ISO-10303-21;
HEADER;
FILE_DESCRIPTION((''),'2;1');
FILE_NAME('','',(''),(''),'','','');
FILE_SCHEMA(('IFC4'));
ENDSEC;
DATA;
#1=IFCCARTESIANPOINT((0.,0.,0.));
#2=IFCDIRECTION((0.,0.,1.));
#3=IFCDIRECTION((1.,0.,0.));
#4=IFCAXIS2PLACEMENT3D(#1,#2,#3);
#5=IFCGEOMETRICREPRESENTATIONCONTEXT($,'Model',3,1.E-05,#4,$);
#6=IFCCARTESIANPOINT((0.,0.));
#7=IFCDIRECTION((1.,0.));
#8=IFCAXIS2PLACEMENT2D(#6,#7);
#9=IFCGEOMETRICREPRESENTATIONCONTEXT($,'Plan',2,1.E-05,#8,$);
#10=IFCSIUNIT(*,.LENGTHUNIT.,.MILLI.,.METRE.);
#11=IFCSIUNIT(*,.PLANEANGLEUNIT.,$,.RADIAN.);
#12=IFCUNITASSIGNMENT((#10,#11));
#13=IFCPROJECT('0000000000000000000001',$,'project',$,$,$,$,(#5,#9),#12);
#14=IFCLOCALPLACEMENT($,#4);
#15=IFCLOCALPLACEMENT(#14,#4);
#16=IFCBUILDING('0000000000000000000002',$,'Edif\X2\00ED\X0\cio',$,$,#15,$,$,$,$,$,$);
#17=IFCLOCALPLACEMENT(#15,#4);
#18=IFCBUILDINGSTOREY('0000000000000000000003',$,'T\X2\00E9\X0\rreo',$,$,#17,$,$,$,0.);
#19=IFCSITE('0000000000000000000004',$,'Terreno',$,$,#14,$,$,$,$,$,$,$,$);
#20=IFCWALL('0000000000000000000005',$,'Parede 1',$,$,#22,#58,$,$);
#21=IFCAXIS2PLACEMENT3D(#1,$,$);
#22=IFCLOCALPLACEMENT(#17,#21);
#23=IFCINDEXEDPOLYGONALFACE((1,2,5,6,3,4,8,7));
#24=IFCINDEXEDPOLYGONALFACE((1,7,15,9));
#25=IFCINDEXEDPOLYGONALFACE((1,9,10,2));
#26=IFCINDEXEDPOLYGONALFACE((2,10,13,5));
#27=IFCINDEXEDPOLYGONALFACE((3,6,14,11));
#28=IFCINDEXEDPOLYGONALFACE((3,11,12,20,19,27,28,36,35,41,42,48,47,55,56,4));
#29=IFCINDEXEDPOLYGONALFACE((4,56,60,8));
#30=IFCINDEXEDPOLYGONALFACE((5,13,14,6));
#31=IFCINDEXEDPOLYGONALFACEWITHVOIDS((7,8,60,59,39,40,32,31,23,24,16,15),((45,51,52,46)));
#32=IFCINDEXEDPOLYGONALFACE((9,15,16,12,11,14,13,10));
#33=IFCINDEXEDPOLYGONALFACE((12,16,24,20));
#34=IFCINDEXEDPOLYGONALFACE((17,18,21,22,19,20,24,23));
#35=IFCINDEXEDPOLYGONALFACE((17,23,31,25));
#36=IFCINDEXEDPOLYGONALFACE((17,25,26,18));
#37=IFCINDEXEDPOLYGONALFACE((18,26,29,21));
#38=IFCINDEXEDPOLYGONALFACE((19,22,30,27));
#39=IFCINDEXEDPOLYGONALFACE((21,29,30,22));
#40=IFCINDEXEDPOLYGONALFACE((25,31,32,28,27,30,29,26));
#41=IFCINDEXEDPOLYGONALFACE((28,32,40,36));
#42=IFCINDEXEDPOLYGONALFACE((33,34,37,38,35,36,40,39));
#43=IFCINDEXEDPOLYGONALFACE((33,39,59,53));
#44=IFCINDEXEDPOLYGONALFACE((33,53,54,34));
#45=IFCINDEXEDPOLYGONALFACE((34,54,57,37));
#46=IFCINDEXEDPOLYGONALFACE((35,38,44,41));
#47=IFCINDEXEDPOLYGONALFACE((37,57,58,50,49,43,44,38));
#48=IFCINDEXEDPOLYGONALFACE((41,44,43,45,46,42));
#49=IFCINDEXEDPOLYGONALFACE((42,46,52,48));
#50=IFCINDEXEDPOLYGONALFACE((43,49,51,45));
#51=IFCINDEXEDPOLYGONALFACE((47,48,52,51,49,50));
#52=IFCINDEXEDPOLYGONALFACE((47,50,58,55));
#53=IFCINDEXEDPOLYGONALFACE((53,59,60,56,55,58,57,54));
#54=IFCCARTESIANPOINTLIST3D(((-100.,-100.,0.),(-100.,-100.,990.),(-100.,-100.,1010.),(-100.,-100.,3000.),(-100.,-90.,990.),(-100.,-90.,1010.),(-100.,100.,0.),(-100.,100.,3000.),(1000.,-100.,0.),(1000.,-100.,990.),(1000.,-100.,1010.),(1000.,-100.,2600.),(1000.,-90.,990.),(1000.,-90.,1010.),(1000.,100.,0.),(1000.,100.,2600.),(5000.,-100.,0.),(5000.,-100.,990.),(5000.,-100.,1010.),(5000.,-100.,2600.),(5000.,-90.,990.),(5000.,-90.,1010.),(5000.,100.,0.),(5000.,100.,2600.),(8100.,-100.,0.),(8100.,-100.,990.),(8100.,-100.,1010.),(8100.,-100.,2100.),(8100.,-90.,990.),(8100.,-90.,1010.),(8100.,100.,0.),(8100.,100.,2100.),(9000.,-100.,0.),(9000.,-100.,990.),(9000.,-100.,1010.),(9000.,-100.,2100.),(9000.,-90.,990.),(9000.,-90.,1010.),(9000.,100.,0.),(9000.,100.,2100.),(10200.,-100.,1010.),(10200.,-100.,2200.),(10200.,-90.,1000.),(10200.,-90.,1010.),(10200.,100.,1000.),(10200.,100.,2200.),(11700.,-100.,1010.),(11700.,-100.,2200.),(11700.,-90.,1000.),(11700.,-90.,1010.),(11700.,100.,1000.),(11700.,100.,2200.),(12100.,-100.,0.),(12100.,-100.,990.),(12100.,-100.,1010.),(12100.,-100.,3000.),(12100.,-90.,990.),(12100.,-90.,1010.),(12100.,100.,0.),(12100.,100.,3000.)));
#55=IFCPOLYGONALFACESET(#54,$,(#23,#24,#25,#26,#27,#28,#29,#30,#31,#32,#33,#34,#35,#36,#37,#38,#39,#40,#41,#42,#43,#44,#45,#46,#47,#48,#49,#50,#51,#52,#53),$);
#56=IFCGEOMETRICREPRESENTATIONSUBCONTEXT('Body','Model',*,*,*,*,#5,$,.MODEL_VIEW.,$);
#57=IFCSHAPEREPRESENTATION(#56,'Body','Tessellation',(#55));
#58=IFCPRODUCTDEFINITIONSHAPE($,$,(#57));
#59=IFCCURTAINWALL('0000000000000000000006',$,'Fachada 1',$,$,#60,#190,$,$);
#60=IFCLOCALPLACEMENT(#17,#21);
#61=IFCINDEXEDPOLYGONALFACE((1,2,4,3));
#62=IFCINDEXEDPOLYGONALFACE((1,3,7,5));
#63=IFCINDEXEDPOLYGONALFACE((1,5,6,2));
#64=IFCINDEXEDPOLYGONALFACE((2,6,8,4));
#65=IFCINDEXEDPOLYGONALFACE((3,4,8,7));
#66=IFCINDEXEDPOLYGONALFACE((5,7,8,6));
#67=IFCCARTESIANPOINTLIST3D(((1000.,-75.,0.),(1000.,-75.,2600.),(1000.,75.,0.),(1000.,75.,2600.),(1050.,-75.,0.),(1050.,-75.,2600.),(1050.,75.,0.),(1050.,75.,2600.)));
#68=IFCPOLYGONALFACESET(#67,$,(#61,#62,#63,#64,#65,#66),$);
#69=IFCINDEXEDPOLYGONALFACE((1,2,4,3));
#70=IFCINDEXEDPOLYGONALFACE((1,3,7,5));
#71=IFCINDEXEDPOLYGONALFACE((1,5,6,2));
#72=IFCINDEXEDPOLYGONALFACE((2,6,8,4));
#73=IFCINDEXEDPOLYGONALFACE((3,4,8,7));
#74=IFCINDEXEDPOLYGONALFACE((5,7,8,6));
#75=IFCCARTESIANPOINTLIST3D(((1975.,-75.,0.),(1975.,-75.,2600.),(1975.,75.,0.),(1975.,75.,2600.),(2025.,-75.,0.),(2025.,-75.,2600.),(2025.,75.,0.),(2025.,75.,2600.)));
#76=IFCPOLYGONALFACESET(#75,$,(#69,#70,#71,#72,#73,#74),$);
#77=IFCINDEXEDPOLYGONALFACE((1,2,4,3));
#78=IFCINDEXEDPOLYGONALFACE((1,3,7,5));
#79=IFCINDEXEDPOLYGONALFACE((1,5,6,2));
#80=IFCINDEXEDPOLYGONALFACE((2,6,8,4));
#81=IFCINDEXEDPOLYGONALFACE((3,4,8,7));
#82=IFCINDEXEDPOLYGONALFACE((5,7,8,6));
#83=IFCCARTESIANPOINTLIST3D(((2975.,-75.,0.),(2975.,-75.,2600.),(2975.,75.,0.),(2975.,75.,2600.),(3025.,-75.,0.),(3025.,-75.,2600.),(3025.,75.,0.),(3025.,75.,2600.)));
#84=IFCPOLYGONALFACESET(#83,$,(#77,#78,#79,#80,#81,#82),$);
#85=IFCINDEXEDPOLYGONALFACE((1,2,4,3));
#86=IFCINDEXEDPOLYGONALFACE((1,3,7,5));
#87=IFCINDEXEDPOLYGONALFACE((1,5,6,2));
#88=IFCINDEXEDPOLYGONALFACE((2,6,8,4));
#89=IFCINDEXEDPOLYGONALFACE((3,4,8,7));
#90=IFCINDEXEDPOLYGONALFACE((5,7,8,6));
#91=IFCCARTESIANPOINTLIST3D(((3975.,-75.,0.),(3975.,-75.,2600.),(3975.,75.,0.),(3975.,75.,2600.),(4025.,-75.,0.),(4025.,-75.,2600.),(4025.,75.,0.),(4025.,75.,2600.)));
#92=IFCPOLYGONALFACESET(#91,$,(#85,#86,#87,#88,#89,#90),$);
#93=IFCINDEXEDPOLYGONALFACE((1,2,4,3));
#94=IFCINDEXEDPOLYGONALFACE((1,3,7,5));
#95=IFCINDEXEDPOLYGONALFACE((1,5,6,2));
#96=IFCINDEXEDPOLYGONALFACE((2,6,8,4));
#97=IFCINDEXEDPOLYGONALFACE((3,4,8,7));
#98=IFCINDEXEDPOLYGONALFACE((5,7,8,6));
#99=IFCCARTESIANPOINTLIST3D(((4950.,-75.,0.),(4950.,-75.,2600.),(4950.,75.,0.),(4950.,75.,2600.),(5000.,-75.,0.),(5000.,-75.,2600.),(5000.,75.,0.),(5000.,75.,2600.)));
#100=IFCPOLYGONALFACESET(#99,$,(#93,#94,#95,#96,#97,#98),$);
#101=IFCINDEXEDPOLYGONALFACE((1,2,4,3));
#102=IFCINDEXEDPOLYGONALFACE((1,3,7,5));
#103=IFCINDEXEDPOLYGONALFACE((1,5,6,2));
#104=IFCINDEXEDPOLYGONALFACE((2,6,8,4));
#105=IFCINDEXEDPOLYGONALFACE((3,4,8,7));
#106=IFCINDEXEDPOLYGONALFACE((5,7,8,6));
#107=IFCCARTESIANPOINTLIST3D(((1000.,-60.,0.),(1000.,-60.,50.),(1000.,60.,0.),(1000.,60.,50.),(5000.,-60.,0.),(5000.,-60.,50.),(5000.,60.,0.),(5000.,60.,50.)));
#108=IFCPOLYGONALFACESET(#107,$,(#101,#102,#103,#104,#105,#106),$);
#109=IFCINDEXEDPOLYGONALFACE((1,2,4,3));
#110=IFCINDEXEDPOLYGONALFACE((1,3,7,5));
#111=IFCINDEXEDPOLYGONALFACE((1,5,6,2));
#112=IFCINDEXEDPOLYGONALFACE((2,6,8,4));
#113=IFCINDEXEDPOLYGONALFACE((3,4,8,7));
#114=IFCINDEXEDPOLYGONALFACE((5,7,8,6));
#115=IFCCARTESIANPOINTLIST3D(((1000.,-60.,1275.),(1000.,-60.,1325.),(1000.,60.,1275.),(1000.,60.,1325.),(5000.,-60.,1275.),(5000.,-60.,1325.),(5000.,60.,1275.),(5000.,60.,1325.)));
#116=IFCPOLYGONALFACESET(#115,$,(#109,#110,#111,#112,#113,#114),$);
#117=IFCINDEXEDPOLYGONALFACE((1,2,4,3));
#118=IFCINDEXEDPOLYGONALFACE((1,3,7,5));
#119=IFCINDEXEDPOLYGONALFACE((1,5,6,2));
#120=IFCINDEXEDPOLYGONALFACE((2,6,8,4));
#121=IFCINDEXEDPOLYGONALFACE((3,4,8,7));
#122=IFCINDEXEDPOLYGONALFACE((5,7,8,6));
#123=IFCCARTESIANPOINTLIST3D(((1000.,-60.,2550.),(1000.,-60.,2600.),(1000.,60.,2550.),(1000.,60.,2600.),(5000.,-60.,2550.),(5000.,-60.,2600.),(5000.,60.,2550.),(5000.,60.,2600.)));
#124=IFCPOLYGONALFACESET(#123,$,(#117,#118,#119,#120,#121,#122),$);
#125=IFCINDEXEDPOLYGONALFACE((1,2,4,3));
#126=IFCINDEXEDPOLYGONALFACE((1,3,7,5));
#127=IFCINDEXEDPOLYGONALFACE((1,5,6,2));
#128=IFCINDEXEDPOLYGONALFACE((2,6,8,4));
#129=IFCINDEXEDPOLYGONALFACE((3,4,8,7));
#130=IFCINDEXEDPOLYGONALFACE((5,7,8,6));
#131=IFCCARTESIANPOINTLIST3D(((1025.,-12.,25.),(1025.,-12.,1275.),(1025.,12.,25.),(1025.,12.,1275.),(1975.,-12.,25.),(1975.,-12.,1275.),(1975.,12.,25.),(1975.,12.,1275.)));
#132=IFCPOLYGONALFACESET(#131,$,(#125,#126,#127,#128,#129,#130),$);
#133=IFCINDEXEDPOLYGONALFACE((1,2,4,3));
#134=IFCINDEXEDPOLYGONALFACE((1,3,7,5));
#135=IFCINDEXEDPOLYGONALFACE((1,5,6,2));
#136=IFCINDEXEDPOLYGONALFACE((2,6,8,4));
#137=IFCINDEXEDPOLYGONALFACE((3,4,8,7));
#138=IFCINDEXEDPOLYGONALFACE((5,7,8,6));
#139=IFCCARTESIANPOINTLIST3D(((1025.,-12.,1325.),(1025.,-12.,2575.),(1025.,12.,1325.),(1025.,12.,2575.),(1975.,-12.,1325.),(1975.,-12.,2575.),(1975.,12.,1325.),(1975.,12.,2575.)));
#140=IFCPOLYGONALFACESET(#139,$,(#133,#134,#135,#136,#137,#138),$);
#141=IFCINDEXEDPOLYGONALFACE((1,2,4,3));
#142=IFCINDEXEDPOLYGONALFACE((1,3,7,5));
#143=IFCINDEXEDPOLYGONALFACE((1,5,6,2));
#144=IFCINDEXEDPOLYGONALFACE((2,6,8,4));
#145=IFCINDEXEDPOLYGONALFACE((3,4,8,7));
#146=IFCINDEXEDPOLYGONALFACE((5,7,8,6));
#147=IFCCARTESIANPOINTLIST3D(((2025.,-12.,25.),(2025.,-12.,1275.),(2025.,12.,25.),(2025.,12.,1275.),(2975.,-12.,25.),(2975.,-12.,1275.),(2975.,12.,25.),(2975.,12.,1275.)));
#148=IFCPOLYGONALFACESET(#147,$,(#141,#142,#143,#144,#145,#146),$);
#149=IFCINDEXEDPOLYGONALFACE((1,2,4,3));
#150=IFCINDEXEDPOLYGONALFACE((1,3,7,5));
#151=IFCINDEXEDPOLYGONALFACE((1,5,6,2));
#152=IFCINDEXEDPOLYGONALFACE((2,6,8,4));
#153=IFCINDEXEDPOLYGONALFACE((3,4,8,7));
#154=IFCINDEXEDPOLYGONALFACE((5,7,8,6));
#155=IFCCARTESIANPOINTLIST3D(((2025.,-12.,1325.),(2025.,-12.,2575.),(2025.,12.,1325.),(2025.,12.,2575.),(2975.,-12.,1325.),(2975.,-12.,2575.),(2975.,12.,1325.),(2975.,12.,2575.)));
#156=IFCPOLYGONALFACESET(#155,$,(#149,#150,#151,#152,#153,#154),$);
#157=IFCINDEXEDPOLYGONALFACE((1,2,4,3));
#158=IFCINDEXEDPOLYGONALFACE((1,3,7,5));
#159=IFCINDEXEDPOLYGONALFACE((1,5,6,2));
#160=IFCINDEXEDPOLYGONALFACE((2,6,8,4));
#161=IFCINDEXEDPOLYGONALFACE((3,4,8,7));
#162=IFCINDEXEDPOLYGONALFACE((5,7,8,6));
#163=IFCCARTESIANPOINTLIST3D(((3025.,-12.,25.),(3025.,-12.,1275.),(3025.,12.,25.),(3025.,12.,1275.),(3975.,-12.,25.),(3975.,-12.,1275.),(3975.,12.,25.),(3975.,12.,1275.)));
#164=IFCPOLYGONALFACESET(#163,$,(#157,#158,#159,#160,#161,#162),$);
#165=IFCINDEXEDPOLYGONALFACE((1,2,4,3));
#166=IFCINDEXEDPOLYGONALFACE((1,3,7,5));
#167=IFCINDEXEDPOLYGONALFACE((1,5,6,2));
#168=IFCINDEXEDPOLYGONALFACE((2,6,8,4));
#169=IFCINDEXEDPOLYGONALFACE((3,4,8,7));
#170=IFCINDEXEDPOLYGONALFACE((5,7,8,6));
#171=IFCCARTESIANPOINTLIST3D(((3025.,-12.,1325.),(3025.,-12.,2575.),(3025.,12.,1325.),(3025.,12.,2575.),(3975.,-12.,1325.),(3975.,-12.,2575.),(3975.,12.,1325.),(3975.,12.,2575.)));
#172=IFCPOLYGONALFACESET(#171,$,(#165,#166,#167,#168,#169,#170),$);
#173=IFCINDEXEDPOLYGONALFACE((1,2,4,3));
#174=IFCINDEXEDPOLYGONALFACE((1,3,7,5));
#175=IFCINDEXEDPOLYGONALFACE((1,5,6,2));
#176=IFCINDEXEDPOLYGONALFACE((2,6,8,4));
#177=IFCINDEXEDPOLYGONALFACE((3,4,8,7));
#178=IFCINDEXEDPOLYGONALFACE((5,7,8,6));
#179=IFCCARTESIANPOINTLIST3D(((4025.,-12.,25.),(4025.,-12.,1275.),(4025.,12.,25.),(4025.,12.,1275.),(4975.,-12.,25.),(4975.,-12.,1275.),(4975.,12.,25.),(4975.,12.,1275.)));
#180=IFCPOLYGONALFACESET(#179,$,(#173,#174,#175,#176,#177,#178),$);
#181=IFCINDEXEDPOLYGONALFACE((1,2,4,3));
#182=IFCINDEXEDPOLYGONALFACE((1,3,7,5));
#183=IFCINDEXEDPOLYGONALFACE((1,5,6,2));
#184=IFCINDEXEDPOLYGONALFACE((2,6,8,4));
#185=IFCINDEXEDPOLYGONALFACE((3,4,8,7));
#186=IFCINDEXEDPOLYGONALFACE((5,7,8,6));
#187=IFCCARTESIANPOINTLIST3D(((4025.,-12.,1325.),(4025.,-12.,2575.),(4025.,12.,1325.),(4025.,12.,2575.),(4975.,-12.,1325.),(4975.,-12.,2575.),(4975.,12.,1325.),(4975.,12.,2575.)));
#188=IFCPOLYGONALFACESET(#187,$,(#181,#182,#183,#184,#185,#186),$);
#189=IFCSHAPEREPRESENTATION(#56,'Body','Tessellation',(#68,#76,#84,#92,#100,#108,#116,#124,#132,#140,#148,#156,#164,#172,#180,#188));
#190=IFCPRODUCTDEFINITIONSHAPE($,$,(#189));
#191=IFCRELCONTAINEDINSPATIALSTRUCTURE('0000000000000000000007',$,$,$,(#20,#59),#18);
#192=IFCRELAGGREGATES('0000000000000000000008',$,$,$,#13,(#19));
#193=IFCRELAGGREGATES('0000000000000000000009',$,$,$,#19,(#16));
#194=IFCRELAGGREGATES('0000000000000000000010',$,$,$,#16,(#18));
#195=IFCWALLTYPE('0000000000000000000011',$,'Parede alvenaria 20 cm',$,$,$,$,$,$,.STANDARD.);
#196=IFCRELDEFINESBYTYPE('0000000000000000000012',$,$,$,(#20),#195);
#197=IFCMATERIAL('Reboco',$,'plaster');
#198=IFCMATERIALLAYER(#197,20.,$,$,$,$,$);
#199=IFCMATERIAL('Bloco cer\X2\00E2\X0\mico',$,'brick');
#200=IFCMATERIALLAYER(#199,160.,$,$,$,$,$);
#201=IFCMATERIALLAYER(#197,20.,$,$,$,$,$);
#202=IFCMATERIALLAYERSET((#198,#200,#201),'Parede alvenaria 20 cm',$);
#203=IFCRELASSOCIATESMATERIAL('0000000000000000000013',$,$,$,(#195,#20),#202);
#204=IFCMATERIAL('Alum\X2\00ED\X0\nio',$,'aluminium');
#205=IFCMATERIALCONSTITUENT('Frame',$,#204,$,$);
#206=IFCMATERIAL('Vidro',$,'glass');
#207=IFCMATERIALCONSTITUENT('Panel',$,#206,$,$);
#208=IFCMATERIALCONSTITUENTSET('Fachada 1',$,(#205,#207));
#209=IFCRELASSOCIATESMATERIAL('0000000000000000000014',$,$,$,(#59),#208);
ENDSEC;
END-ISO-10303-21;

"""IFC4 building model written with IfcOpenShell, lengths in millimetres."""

from ifc_helpers import new_model, si_unit, frame, origin_with_axes, origin_2d, origin_2d_with_axis, place, context, subcontext, project, spatial, indexed_curve, rectangle, outline, extrude, material, layer, layer_set, layer_usage, constituent, constituent_set, type_object, element, fill, save


model = new_model("IFC4")

# Units and contexts
model_context = context("Model", 3, precision=1e-05, world=origin_with_axes())
plan_context = context("Plan", 2, precision=1e-05, world=origin_2d_with_axis())
body_context = subcontext(model_context, "Body", "Model", "MODEL_VIEW")
ifc_project = project(units=[si_unit("LENGTHUNIT", "METRE", prefix="MILLI"), si_unit("PLANEANGLEUNIT", "RADIAN")], contexts=[model_context, plan_context])

# Site, building, storey
site_placement = place(None, origin_with_axes())
site = spatial("IfcSite", under=ifc_project, at=site_placement, Name="Terreno")
building_placement = place(site_placement, origin_with_axes())
building = spatial("IfcBuilding", under=site, at=building_placement, Name="Edifício")
storey_placement = place(building_placement, origin_with_axes())
storey = spatial("IfcBuildingStorey", under=building, at=storey_placement, Name="Térreo", Elevation=0.0)

# Wall, openings, curtain wall
ifc_material_1 = material(Name="Reboco", Category="plaster")
ifc_layer_1 = layer(ifc_material_1, 20.0)
ifc_material_2 = material(Name="Bloco cerâmico", Category="brick")
ifc_layer_2 = layer(ifc_material_2, 160.0)
ifc_layer_3 = layer(ifc_material_1, 20.0)
ifc_layer_set_1 = layer_set([ifc_layer_1, ifc_layer_2, ifc_layer_3], Name="Parede alvenaria 20 cm")
ifc_layer_usage_1 = layer_usage(ifc_layer_set_1, "AXIS2", "POSITIVE", -100.0)
wall_type_1 = type_object("IfcWallType", Name="Parede alvenaria 20 cm", PredefinedType="STANDARD", material=ifc_layer_set_1)
wall_1_placement = place(storey_placement, frame((-100.0, 0.0, 0.0), z_axis=(0.0, 0.0, 1.0), x_axis=(1.0, 0.0, 0.0)))
wall_1 = element("IfcWall", 1, at=wall_1_placement, inside=storey, type_object=wall_type_1, material=ifc_layer_usage_1, Name="Parede 1", context=body_context, shape_type="SweptSolid", body=[
    extrude(outline(indexed_curve([(0.0, 0.0), (0.0, 200.0), (12200.0, 200.0), (12200.0, 0.0), (0.0, 0.0)], self_intersect=False)), frame((0.0, -100.0, 0.0), z_axis=(0.0, 0.0, 1.0), x_axis=(1.0, 0.0, 0.0)), (0.0, 0.0, 1.0), 3000.0),
])
opening_1_placement = place(wall_1_placement, frame((8200.0, -110.0, 0.0), z_axis=(0.0, 0.0, 1.0), x_axis=(1.0, 0.0, 0.0)))
element("IfcOpeningElement", 2, at=opening_1_placement, cuts=wall_1, context=body_context, shape_type="SweptSolid", body=[
    extrude(outline(indexed_curve([(0.0, 0.0), (0.0, 220.0), (900.0, 220.0), (900.0, 0.0), (0.0, 0.0)], self_intersect=False)), origin_with_axes(), (0.0, 0.0, 1.0), 2100.0),
])
opening_2_placement = place(wall_1_placement, frame((10300.0, -110.0, 1000.0), z_axis=(0.0, 0.0, 1.0), x_axis=(1.0, 0.0, 0.0)))
element("IfcOpeningElement", 3, at=opening_2_placement, cuts=wall_1, context=body_context, shape_type="SweptSolid", body=[
    extrude(outline(indexed_curve([(0.0, 0.0), (0.0, 220.0), (1500.0, 220.0), (1500.0, 0.0), (0.0, 0.0)], self_intersect=False)), origin_with_axes(), (0.0, 0.0, 1.0), 1200.0),
])
opening_3_placement = place(wall_1_placement, frame((1100.0, -110.0, 0.0), z_axis=(0.0, 0.0, 1.0), x_axis=(1.0, 0.0, 0.0)))
opening_3 = element("IfcOpeningElement", 4, at=opening_3_placement, cuts=wall_1, PredefinedType="OPENING", context=body_context, shape_type="SweptSolid", body=[
    extrude(outline(indexed_curve([(0.0, 0.0), (0.0, 220.0), (4000.0, 220.0), (4000.0, 0.0), (0.0, 0.0)], self_intersect=False)), origin_with_axes(), (0.0, 0.0, 1.0), 2600.0),
])
opening_4_placement = place(wall_1_placement, frame((-200.0, -110.0, 990.0), z_axis=(0.0, 0.0, 1.0), x_axis=(1.0, 0.0, 0.0)))
element("IfcOpeningElement", 5, at=opening_4_placement, cuts=wall_1, PredefinedType="RECESS", context=body_context, shape_type="SweptSolid", body=[
    extrude(outline(indexed_curve([(0.0, 0.0), (0.0, 20.0), (12600.0, 20.0), (12600.0, 0.0), (0.0, 0.0)], self_intersect=False)), origin_with_axes(), (0.0, 0.0, 1.0), 20.0),
])
ifc_material_3 = material(Name="Alumínio", Category="aluminium")
ifc_constituent_1 = constituent(ifc_material_3, Name="Frame")
ifc_material_4 = material(Name="Vidro", Category="glass")
ifc_constituent_2 = constituent(ifc_material_4, Name="Panel")
ifc_constituent_set = constituent_set(constituents=[ifc_constituent_1, ifc_constituent_2], Name="Fachada 1")
curtain_wall_placement = place(opening_3_placement, frame((0.0, 110.0, 0.0), z_axis=(0.0, 0.0, 1.0), x_axis=(1.0, 0.0, 0.0)))
curtain_wall = element("IfcCurtainWall", 6, at=curtain_wall_placement, inside=storey, material=ifc_constituent_set, Name="Fachada 1", context=body_context, shape_type="SweptSolid", body=[
    extrude(rectangle(XDim=50.0, YDim=150.0, at=origin_2d()), frame((25.0, 0.0, 0.0), z_axis=(0.0, 0.0, 1.0), x_axis=(1.0, 0.0, 0.0)), (0.0, 0.0, 1.0), 2600.0),
    extrude(rectangle(XDim=50.0, YDim=150.0, at=origin_2d()), frame((1000.0, 0.0, 0.0), z_axis=(0.0, 0.0, 1.0), x_axis=(1.0, 0.0, 0.0)), (0.0, 0.0, 1.0), 2600.0),
    extrude(rectangle(XDim=50.0, YDim=150.0, at=origin_2d()), frame((2000.0, 0.0, 0.0), z_axis=(0.0, 0.0, 1.0), x_axis=(1.0, 0.0, 0.0)), (0.0, 0.0, 1.0), 2600.0),
    extrude(rectangle(XDim=50.0, YDim=150.0, at=origin_2d()), frame((3000.0, 0.0, 0.0), z_axis=(0.0, 0.0, 1.0), x_axis=(1.0, 0.0, 0.0)), (0.0, 0.0, 1.0), 2600.0),
    extrude(rectangle(XDim=50.0, YDim=150.0, at=origin_2d()), frame((3975.0, 0.0, 0.0), z_axis=(0.0, 0.0, 1.0), x_axis=(1.0, 0.0, 0.0)), (0.0, 0.0, 1.0), 2600.0),
    extrude(rectangle(XDim=120.0, YDim=50.0, at=origin_2d()), frame((0.0, 0.0, 25.0), z_axis=(1.0, 0.0, 0.0), x_axis=(0.0, 1.0, 0.0)), (0.0, 0.0, 1.0), 4000.0),
    extrude(rectangle(XDim=120.0, YDim=50.0, at=origin_2d()), frame((0.0, 0.0, 1300.0), z_axis=(1.0, 0.0, 0.0), x_axis=(0.0, 1.0, 0.0)), (0.0, 0.0, 1.0), 4000.0),
    extrude(rectangle(XDim=120.0, YDim=50.0, at=origin_2d()), frame((0.0, 0.0, 2575.0), z_axis=(1.0, 0.0, 0.0), x_axis=(0.0, 1.0, 0.0)), (0.0, 0.0, 1.0), 4000.0),
    extrude(rectangle(XDim=24.0, YDim=1250.0, at=origin_2d()), frame((25.0, 0.0, 650.0), z_axis=(1.0, 0.0, 0.0), x_axis=(0.0, 1.0, 0.0)), (0.0, 0.0, 1.0), 950.0),
    extrude(rectangle(XDim=24.0, YDim=1250.0, at=origin_2d()), frame((25.0, 0.0, 1950.0), z_axis=(1.0, 0.0, 0.0), x_axis=(0.0, 1.0, 0.0)), (0.0, 0.0, 1.0), 950.0),
    extrude(rectangle(XDim=24.0, YDim=1250.0, at=origin_2d()), frame((1025.0, 0.0, 650.0), z_axis=(1.0, 0.0, 0.0), x_axis=(0.0, 1.0, 0.0)), (0.0, 0.0, 1.0), 950.0),
    extrude(rectangle(XDim=24.0, YDim=1250.0, at=origin_2d()), frame((1025.0, 0.0, 1950.0), z_axis=(1.0, 0.0, 0.0), x_axis=(0.0, 1.0, 0.0)), (0.0, 0.0, 1.0), 950.0),
    extrude(rectangle(XDim=24.0, YDim=1250.0, at=origin_2d()), frame((2025.0, 0.0, 650.0), z_axis=(1.0, 0.0, 0.0), x_axis=(0.0, 1.0, 0.0)), (0.0, 0.0, 1.0), 950.0),
    extrude(rectangle(XDim=24.0, YDim=1250.0, at=origin_2d()), frame((2025.0, 0.0, 1950.0), z_axis=(1.0, 0.0, 0.0), x_axis=(0.0, 1.0, 0.0)), (0.0, 0.0, 1.0), 950.0),
    extrude(rectangle(XDim=24.0, YDim=1250.0, at=origin_2d()), frame((3025.0, 0.0, 650.0), z_axis=(1.0, 0.0, 0.0), x_axis=(0.0, 1.0, 0.0)), (0.0, 0.0, 1.0), 950.0),
    extrude(rectangle(XDim=24.0, YDim=1250.0, at=origin_2d()), frame((3025.0, 0.0, 1950.0), z_axis=(1.0, 0.0, 0.0), x_axis=(0.0, 1.0, 0.0)), (0.0, 0.0, 1.0), 950.0),
])
fill(opening_3, curtain_wall)

save(model, "model.ifc")
